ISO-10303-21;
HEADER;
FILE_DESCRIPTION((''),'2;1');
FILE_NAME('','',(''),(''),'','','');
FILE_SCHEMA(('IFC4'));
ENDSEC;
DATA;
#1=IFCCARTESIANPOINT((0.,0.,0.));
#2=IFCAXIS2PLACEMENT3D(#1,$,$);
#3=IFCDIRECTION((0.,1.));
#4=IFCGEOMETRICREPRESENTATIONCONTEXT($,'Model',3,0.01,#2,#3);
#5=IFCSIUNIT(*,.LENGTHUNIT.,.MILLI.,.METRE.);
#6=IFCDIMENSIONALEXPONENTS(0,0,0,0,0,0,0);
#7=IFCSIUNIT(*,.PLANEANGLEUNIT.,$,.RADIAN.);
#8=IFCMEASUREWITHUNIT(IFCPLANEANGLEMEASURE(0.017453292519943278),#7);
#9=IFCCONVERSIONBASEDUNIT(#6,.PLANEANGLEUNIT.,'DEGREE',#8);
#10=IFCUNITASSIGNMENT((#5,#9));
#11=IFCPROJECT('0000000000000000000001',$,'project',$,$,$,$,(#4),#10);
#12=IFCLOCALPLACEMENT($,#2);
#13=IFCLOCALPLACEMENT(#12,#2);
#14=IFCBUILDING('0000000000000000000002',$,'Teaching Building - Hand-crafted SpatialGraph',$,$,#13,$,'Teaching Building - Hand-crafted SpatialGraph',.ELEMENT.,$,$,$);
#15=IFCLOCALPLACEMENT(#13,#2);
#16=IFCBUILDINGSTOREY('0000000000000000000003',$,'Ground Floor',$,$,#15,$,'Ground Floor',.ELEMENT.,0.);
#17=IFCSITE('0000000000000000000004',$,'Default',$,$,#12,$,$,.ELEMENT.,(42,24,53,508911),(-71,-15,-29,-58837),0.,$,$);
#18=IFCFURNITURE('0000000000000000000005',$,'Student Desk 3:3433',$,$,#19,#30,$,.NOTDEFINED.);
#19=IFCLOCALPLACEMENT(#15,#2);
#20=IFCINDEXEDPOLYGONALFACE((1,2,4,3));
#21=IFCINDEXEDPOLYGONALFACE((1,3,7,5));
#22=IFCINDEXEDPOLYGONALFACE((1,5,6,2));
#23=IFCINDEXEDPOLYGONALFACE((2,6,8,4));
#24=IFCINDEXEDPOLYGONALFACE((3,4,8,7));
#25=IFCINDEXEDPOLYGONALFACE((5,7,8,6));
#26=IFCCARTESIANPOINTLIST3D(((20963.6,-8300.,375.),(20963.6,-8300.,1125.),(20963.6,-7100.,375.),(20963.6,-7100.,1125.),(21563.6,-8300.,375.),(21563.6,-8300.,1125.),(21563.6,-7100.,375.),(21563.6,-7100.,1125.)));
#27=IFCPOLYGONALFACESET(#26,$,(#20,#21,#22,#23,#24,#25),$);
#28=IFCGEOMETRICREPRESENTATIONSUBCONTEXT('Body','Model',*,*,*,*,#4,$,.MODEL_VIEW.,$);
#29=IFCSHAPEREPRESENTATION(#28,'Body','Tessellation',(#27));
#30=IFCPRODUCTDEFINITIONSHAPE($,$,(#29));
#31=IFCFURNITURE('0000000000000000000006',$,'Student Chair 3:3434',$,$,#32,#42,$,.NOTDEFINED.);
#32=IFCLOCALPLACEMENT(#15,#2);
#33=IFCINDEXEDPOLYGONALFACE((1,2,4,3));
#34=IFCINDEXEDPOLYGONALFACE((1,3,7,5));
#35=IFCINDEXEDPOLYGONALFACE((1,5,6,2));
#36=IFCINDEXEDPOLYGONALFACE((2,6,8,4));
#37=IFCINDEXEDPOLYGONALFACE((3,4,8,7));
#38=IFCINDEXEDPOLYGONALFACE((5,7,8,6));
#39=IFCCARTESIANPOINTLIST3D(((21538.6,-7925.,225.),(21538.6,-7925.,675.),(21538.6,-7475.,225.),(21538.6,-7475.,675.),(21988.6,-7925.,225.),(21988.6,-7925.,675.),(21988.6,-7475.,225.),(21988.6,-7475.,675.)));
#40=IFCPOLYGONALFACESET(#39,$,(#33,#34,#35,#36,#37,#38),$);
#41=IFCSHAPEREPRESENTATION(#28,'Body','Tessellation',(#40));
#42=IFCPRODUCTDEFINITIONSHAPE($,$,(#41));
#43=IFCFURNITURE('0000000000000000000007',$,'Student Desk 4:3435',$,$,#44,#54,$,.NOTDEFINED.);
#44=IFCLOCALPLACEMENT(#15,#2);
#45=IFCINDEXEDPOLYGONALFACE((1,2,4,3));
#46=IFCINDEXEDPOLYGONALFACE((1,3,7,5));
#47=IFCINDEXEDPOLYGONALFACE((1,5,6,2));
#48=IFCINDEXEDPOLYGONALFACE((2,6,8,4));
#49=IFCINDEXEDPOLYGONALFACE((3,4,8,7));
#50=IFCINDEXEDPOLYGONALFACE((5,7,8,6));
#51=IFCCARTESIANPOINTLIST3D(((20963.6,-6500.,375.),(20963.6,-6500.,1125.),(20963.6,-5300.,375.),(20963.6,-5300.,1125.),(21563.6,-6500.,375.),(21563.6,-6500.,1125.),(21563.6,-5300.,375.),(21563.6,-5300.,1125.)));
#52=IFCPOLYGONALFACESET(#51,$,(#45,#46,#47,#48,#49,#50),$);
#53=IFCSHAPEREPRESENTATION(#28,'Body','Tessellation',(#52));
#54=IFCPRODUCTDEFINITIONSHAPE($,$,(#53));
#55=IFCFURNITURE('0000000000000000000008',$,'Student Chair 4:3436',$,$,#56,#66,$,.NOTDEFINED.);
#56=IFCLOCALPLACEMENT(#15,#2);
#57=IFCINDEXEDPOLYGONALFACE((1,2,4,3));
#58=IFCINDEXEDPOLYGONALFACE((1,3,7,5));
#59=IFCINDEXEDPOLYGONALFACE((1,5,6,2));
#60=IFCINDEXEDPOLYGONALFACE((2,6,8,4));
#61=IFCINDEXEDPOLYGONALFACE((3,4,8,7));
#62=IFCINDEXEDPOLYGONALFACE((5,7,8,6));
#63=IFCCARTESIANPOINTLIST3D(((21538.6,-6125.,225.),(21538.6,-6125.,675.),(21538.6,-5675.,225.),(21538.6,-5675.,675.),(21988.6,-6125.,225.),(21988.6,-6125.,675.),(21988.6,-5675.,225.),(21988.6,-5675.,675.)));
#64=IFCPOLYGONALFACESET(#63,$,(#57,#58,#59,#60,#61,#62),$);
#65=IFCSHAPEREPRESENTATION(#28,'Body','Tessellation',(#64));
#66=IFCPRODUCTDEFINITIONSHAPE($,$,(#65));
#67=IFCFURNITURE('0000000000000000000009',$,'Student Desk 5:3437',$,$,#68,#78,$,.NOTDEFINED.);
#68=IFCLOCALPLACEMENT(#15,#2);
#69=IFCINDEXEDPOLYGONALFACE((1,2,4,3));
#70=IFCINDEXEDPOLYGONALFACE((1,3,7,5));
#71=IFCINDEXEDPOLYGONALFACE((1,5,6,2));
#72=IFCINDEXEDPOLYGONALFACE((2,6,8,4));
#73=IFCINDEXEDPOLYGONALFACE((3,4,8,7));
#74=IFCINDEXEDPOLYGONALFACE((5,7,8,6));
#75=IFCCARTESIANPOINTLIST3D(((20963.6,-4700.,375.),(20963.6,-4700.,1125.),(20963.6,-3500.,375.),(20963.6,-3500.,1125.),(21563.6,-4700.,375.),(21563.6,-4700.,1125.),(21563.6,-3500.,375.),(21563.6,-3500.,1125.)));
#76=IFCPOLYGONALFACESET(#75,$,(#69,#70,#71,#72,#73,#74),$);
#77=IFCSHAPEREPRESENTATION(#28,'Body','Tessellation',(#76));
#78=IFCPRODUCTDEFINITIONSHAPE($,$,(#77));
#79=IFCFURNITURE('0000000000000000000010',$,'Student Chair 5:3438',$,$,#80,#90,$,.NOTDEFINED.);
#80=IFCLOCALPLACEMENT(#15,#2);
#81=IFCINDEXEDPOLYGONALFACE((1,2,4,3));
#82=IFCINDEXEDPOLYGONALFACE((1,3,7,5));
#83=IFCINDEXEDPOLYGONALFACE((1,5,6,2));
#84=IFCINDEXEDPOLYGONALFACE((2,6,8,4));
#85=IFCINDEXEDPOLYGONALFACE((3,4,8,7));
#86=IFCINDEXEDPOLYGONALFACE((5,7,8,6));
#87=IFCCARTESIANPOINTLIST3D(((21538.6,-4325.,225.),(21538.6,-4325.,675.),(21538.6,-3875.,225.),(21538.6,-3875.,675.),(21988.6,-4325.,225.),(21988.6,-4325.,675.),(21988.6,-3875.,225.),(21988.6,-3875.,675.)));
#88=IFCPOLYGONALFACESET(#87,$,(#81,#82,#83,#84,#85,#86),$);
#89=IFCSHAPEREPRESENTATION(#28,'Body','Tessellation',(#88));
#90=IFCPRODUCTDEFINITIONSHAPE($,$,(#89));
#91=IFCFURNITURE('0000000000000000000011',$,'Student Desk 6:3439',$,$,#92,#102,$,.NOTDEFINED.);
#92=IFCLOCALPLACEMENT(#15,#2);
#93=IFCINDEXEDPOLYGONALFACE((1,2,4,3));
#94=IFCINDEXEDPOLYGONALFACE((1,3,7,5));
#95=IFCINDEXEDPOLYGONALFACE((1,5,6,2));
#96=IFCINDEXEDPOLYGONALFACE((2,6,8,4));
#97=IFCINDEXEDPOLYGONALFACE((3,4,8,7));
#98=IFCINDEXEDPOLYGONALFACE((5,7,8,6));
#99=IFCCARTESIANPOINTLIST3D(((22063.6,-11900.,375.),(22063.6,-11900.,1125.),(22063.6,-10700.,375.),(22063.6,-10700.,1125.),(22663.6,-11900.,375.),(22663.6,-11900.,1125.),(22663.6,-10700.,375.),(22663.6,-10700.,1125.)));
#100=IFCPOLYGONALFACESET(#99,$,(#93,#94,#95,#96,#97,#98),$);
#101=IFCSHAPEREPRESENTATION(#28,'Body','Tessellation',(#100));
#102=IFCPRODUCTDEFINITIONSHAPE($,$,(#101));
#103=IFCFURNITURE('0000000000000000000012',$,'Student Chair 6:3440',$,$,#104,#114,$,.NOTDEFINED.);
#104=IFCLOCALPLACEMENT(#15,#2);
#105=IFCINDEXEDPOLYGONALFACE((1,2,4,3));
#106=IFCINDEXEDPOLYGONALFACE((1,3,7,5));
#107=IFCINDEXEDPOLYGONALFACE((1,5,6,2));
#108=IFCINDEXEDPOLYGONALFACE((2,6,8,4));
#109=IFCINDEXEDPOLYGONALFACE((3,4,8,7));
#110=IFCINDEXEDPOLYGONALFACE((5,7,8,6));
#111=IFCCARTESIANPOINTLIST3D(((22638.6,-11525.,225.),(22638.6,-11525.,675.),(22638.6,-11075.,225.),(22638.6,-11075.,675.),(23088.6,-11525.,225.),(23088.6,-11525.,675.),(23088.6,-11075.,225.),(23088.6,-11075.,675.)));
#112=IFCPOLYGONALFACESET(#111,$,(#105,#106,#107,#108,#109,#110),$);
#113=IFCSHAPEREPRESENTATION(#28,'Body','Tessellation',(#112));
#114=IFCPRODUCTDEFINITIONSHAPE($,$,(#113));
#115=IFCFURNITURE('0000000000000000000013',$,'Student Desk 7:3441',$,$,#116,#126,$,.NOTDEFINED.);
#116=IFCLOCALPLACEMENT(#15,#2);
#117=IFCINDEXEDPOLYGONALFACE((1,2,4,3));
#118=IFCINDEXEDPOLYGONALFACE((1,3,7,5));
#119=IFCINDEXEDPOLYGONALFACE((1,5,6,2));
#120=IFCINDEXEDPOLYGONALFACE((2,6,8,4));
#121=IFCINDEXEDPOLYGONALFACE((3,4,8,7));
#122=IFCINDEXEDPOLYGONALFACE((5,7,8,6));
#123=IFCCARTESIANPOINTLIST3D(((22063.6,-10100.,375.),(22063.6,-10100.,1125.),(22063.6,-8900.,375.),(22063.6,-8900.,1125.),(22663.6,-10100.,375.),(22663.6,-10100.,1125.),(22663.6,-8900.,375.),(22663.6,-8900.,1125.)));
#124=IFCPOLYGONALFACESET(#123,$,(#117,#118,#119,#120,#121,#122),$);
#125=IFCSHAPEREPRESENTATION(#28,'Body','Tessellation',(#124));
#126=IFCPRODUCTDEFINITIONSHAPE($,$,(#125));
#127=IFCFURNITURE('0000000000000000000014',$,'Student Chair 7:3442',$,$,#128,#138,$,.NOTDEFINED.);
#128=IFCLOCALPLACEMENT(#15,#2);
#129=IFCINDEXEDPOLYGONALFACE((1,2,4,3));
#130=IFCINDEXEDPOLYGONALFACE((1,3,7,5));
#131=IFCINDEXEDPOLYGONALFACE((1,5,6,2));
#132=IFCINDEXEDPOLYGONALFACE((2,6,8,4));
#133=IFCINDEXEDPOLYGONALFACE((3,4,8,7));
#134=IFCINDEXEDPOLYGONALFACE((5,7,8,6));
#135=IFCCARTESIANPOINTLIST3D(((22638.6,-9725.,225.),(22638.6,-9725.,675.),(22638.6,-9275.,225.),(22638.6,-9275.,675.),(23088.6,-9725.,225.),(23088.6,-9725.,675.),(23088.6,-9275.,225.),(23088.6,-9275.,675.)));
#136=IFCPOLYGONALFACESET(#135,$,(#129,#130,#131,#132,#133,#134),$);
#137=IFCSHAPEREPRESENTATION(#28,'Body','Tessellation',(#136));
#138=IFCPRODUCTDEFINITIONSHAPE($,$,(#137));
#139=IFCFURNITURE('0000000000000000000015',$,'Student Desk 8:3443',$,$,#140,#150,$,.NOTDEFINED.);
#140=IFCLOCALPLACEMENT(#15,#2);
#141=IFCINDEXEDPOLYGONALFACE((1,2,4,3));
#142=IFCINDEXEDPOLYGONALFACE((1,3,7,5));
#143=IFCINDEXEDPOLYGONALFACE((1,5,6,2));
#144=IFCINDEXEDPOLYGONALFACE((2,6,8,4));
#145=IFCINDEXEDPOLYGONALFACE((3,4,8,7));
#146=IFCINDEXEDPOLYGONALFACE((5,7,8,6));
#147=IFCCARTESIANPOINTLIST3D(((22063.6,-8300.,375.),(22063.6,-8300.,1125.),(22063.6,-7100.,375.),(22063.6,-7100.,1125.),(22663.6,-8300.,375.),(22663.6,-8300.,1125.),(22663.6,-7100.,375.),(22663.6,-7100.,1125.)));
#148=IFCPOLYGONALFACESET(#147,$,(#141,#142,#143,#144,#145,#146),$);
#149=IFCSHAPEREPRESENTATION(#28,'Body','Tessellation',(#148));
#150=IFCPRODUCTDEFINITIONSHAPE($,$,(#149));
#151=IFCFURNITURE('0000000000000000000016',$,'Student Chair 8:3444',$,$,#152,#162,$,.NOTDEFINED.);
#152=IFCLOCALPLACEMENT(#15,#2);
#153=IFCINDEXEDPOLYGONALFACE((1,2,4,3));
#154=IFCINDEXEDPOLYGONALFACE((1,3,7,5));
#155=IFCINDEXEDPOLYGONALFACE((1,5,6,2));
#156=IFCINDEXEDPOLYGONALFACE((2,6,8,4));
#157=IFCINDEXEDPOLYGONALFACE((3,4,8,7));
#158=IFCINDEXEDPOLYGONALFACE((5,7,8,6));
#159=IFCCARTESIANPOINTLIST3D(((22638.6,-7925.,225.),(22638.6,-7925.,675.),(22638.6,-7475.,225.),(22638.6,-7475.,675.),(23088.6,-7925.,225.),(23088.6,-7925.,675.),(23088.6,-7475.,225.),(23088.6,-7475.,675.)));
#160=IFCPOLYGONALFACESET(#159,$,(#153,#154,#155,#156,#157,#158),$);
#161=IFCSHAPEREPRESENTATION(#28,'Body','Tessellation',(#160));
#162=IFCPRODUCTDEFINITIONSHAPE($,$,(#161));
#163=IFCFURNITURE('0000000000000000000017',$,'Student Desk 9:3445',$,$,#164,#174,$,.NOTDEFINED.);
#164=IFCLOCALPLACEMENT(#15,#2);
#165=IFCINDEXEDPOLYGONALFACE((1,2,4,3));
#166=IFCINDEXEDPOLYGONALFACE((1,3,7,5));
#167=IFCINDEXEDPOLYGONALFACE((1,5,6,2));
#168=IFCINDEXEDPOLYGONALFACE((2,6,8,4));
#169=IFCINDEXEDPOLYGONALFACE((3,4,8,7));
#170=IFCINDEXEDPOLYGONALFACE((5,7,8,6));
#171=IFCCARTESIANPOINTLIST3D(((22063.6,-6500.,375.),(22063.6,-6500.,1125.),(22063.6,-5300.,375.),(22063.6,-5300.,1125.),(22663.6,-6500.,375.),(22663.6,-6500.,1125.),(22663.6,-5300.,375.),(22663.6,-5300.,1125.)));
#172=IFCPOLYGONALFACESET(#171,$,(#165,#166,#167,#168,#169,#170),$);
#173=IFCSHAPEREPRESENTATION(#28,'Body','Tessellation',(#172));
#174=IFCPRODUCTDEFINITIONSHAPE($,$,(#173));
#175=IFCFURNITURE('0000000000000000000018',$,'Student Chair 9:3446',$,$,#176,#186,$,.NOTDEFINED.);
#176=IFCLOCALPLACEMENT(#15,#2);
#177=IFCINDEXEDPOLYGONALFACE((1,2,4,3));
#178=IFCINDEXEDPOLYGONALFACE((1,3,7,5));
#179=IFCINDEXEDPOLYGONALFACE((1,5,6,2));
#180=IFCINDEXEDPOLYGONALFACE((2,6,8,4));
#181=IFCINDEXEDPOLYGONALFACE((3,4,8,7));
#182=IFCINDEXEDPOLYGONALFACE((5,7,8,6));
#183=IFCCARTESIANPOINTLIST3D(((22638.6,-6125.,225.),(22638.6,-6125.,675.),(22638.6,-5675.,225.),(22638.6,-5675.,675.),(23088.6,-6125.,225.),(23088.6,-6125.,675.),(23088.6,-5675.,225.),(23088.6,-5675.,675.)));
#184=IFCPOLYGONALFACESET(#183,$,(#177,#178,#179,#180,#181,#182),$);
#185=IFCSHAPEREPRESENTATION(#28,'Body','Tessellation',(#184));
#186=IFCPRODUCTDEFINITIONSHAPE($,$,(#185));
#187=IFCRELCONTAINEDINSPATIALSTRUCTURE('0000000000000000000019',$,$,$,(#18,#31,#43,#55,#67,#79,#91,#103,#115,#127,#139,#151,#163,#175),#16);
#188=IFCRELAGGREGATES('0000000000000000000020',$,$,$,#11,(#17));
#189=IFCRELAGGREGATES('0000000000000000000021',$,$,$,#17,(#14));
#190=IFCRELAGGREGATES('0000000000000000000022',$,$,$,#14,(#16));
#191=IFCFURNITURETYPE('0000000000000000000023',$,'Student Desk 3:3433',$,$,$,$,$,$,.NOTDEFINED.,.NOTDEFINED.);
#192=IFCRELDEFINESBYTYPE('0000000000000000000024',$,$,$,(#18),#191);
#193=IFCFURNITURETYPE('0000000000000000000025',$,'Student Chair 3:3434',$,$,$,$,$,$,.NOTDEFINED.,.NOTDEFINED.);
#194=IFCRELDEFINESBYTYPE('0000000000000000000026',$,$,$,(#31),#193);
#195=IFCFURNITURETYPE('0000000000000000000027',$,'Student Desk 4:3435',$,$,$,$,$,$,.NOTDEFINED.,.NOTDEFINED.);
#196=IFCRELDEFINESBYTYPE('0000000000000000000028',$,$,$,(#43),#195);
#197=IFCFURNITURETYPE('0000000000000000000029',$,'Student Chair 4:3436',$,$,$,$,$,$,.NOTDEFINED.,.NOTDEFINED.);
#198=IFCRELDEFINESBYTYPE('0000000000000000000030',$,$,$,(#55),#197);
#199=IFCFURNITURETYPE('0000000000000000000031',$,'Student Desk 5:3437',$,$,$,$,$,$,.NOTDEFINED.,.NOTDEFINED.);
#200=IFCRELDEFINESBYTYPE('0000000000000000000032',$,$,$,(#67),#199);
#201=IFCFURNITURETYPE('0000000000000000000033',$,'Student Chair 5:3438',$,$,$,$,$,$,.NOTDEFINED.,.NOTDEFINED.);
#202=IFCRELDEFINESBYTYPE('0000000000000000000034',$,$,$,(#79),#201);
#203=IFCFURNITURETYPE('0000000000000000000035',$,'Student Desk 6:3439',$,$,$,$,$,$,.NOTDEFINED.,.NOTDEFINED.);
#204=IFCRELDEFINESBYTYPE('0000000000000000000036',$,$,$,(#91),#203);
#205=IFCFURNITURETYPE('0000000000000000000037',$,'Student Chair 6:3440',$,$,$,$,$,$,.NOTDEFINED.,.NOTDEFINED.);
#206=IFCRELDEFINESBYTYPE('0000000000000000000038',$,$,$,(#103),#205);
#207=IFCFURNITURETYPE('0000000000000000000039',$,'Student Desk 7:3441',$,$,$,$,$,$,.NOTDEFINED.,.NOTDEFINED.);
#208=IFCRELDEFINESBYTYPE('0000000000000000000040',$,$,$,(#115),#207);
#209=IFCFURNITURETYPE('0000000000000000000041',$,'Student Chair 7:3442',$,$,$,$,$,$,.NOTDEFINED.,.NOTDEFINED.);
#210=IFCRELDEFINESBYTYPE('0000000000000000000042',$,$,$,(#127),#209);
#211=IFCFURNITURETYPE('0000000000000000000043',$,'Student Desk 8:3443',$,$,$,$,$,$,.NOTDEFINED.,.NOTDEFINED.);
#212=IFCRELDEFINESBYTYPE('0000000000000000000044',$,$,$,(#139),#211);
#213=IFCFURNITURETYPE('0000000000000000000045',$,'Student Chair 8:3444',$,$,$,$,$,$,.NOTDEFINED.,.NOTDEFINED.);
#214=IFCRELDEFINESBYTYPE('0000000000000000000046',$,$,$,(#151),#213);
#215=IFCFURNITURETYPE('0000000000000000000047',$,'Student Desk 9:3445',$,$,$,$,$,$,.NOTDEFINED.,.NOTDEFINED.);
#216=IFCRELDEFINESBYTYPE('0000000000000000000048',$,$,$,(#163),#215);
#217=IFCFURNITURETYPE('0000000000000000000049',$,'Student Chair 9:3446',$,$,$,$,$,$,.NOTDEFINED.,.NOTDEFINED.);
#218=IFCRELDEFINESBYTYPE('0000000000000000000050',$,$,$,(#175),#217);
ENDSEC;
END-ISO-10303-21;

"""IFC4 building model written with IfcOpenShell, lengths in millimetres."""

from ifc_helpers import new_model, entity, si_unit, converted_unit, direction, frame, frame_2d, origin, origin_2d_with_axis, place, context, subcontext, project, spatial, rectangle, extrude, type_object, element, save


model = new_model("IFC4")

# Units and contexts
model_context = context("Model", 3, precision=0.01, world=origin(), true_north=direction((0.0, 1.0)))
body_context = subcontext(model_context, "Body", "Model", "MODEL_VIEW")
ifc_project = project(units=[si_unit("LENGTHUNIT", "METRE", prefix="MILLI"), converted_unit("PLANEANGLEUNIT", "DEGREE", entity("IfcPlaneAngleMeasure", 0.017453292519943278), si_unit("PLANEANGLEUNIT", "RADIAN"), dimensions=[0, 0, 0, 0, 0, 0, 0])], contexts=[model_context])

# Site, building, storey
site_placement = place(None, origin())
site = spatial("IfcSite", under=ifc_project, at=site_placement, Name="Default", CompositionType="ELEMENT", RefLatitude=(42, 24, 53, 508911), RefLongitude=(-71, -15, -29, -58837), RefElevation=0.0)
building_placement = place(site_placement, origin())
building = spatial("IfcBuilding", under=site, at=building_placement, Name="Teaching Building - Hand-crafted SpatialGraph", LongName="Teaching Building - Hand-crafted SpatialGraph", CompositionType="ELEMENT")
storey_placement = place(building_placement, origin())
storey = spatial("IfcBuildingStorey", under=building, at=storey_placement, Name="Ground Floor", LongName="Ground Floor", CompositionType="ELEMENT", Elevation=0.0)

# Furniture
furniture_type_1 = type_object("IfcFurnitureType", Name="Student Desk 3:3433", PredefinedType="NOTDEFINED")
furniture_1_placement = place(storey_placement, origin())
element("IfcFurniture", 1, at=furniture_1_placement, inside=storey, type_object=furniture_type_1, Name="Student Desk 3:3433", PredefinedType="NOTDEFINED", context=body_context, shape_type="SweptSolid", body=[
    extrude(rectangle(XDim=1200.0, YDim=600.0, at=origin_2d_with_axis()), frame((21263.6, -7700.0, 375.0), z_axis=(0.0, 0.0, 1.0), x_axis=(0.0, 1.0, 0.0)), (0.0, 0.0, 1.0), 750.0),
])
furniture_type_2 = type_object("IfcFurnitureType", Name="Student Chair 3:3434", PredefinedType="NOTDEFINED")
furniture_2_placement = place(storey_placement, origin())
element("IfcFurniture", 2, at=furniture_2_placement, inside=storey, type_object=furniture_type_2, Name="Student Chair 3:3434", PredefinedType="NOTDEFINED", context=body_context, shape_type="SweptSolid", body=[
    extrude(rectangle(XDim=450.0, YDim=450.0, at=frame_2d((0.0, 0.0), x_axis=(1.0, 0.0))), frame((21763.6, -7700.0, 225.0)), (0.0, 0.0, 1.0), 450.0),
])
furniture_type_3 = type_object("IfcFurnitureType", Name="Student Desk 4:3435", PredefinedType="NOTDEFINED")
furniture_3_placement = place(storey_placement, origin())
element("IfcFurniture", 3, at=furniture_3_placement, inside=storey, type_object=furniture_type_3, Name="Student Desk 4:3435", PredefinedType="NOTDEFINED", context=body_context, shape_type="SweptSolid", body=[
    extrude(rectangle(XDim=1200.0, YDim=600.0, at=origin_2d_with_axis()), frame((21263.6, -5900.0, 375.0), z_axis=(0.0, 0.0, 1.0), x_axis=(0.0, 1.0, 0.0)), (0.0, 0.0, 1.0), 750.0),
])
furniture_type_4 = type_object("IfcFurnitureType", Name="Student Chair 4:3436", PredefinedType="NOTDEFINED")
furniture_4_placement = place(storey_placement, origin())
element("IfcFurniture", 4, at=furniture_4_placement, inside=storey, type_object=furniture_type_4, Name="Student Chair 4:3436", PredefinedType="NOTDEFINED", context=body_context, shape_type="SweptSolid", body=[
    extrude(rectangle(XDim=450.0, YDim=450.0, at=origin_2d_with_axis()), frame((21763.6, -5900.0, 225.0)), (0.0, 0.0, 1.0), 450.0),
])
furniture_type_5 = type_object("IfcFurnitureType", Name="Student Desk 5:3437", PredefinedType="NOTDEFINED")
furniture_5_placement = place(storey_placement, origin())
element("IfcFurniture", 5, at=furniture_5_placement, inside=storey, type_object=furniture_type_5, Name="Student Desk 5:3437", PredefinedType="NOTDEFINED", context=body_context, shape_type="SweptSolid", body=[
    extrude(rectangle(XDim=1200.0, YDim=600.0, at=origin_2d_with_axis()), frame((21263.6, -4100.0, 375.0), z_axis=(0.0, 0.0, 1.0), x_axis=(0.0, 1.0, 0.0)), (0.0, 0.0, 1.0), 750.0),
])
furniture_type_6 = type_object("IfcFurnitureType", Name="Student Chair 5:3438", PredefinedType="NOTDEFINED")
furniture_6_placement = place(storey_placement, origin())
element("IfcFurniture", 6, at=furniture_6_placement, inside=storey, type_object=furniture_type_6, Name="Student Chair 5:3438", PredefinedType="NOTDEFINED", context=body_context, shape_type="SweptSolid", body=[
    extrude(rectangle(XDim=450.0, YDim=450.0, at=origin_2d_with_axis()), frame((21763.6, -4100.0, 225.0)), (0.0, 0.0, 1.0), 450.0),
])
furniture_type_7 = type_object("IfcFurnitureType", Name="Student Desk 6:3439", PredefinedType="NOTDEFINED")
furniture_7_placement = place(storey_placement, origin())
element("IfcFurniture", 7, at=furniture_7_placement, inside=storey, type_object=furniture_type_7, Name="Student Desk 6:3439", PredefinedType="NOTDEFINED", context=body_context, shape_type="SweptSolid", body=[
    extrude(rectangle(XDim=1200.0, YDim=600.0, at=origin_2d_with_axis()), frame((22363.6, -11300.0, 375.0), z_axis=(0.0, 0.0, 1.0), x_axis=(0.0, 1.0, 0.0)), (0.0, 0.0, 1.0), 750.0),
])
furniture_type_8 = type_object("IfcFurnitureType", Name="Student Chair 6:3440", PredefinedType="NOTDEFINED")
furniture_8_placement = place(storey_placement, origin())
element("IfcFurniture", 8, at=furniture_8_placement, inside=storey, type_object=furniture_type_8, Name="Student Chair 6:3440", PredefinedType="NOTDEFINED", context=body_context, shape_type="SweptSolid", body=[
    extrude(rectangle(XDim=450.0, YDim=450.0, at=origin_2d_with_axis()), frame((22863.6, -11300.0, 225.0)), (0.0, 0.0, 1.0), 450.0),
])
furniture_type_9 = type_object("IfcFurnitureType", Name="Student Desk 7:3441", PredefinedType="NOTDEFINED")
furniture_9_placement = place(storey_placement, origin())
element("IfcFurniture", 9, at=furniture_9_placement, inside=storey, type_object=furniture_type_9, Name="Student Desk 7:3441", PredefinedType="NOTDEFINED", context=body_context, shape_type="SweptSolid", body=[
    extrude(rectangle(XDim=1200.0, YDim=600.0, at=origin_2d_with_axis()), frame((22363.6, -9500.0, 375.0), z_axis=(0.0, 0.0, 1.0), x_axis=(0.0, 1.0, 0.0)), (0.0, 0.0, 1.0), 750.0),
])
furniture_type_10 = type_object("IfcFurnitureType", Name="Student Chair 7:3442", PredefinedType="NOTDEFINED")
furniture_10_placement = place(storey_placement, origin())
element("IfcFurniture", 10, at=furniture_10_placement, inside=storey, type_object=furniture_type_10, Name="Student Chair 7:3442", PredefinedType="NOTDEFINED", context=body_context, shape_type="SweptSolid", body=[
    extrude(rectangle(XDim=450.0, YDim=450.0, at=origin_2d_with_axis()), frame((22863.6, -9500.0, 225.0)), (0.0, 0.0, 1.0), 450.0),
])
furniture_type_11 = type_object("IfcFurnitureType", Name="Student Desk 8:3443", PredefinedType="NOTDEFINED")
furniture_11_placement = place(storey_placement, origin())
element("IfcFurniture", 11, at=furniture_11_placement, inside=storey, type_object=furniture_type_11, Name="Student Desk 8:3443", PredefinedType="NOTDEFINED", context=body_context, shape_type="SweptSolid", body=[
    extrude(rectangle(XDim=1200.0, YDim=600.0, at=origin_2d_with_axis()), frame((22363.6, -7700.0, 375.0), z_axis=(0.0, 0.0, 1.0), x_axis=(0.0, 1.0, 0.0)), (0.0, 0.0, 1.0), 750.0),
])
furniture_type_12 = type_object("IfcFurnitureType", Name="Student Chair 8:3444", PredefinedType="NOTDEFINED")
furniture_12_placement = place(storey_placement, origin())
element("IfcFurniture", 12, at=furniture_12_placement, inside=storey, type_object=furniture_type_12, Name="Student Chair 8:3444", PredefinedType="NOTDEFINED", context=body_context, shape_type="SweptSolid", body=[
    extrude(rectangle(XDim=450.0, YDim=450.0, at=frame_2d((0.0, 0.0), x_axis=(1.0, 0.0))), frame((22863.6, -7700.0, 225.0)), (0.0, 0.0, 1.0), 450.0),
])
furniture_type_13 = type_object("IfcFurnitureType", Name="Student Desk 9:3445", PredefinedType="NOTDEFINED")
furniture_13_placement = place(storey_placement, origin())
element("IfcFurniture", 13, at=furniture_13_placement, inside=storey, type_object=furniture_type_13, Name="Student Desk 9:3445", PredefinedType="NOTDEFINED", context=body_context, shape_type="SweptSolid", body=[
    extrude(rectangle(XDim=1200.0, YDim=600.0, at=origin_2d_with_axis()), frame((22363.6, -5900.0, 375.0), z_axis=(0.0, 0.0, 1.0), x_axis=(0.0, 1.0, 0.0)), (0.0, 0.0, 1.0), 750.0),
])
furniture_type_14 = type_object("IfcFurnitureType", Name="Student Chair 9:3446", PredefinedType="NOTDEFINED")
furniture_14_placement = place(storey_placement, origin())
element("IfcFurniture", 14, at=furniture_14_placement, inside=storey, type_object=furniture_type_14, Name="Student Chair 9:3446", PredefinedType="NOTDEFINED", context=body_context, shape_type="SweptSolid", body=[
    extrude(rectangle(XDim=450.0, YDim=450.0, at=origin_2d_with_axis()), frame((22863.6, -5900.0, 225.0)), (0.0, 0.0, 1.0), 450.0),
])

save(model, "model.ifc")
